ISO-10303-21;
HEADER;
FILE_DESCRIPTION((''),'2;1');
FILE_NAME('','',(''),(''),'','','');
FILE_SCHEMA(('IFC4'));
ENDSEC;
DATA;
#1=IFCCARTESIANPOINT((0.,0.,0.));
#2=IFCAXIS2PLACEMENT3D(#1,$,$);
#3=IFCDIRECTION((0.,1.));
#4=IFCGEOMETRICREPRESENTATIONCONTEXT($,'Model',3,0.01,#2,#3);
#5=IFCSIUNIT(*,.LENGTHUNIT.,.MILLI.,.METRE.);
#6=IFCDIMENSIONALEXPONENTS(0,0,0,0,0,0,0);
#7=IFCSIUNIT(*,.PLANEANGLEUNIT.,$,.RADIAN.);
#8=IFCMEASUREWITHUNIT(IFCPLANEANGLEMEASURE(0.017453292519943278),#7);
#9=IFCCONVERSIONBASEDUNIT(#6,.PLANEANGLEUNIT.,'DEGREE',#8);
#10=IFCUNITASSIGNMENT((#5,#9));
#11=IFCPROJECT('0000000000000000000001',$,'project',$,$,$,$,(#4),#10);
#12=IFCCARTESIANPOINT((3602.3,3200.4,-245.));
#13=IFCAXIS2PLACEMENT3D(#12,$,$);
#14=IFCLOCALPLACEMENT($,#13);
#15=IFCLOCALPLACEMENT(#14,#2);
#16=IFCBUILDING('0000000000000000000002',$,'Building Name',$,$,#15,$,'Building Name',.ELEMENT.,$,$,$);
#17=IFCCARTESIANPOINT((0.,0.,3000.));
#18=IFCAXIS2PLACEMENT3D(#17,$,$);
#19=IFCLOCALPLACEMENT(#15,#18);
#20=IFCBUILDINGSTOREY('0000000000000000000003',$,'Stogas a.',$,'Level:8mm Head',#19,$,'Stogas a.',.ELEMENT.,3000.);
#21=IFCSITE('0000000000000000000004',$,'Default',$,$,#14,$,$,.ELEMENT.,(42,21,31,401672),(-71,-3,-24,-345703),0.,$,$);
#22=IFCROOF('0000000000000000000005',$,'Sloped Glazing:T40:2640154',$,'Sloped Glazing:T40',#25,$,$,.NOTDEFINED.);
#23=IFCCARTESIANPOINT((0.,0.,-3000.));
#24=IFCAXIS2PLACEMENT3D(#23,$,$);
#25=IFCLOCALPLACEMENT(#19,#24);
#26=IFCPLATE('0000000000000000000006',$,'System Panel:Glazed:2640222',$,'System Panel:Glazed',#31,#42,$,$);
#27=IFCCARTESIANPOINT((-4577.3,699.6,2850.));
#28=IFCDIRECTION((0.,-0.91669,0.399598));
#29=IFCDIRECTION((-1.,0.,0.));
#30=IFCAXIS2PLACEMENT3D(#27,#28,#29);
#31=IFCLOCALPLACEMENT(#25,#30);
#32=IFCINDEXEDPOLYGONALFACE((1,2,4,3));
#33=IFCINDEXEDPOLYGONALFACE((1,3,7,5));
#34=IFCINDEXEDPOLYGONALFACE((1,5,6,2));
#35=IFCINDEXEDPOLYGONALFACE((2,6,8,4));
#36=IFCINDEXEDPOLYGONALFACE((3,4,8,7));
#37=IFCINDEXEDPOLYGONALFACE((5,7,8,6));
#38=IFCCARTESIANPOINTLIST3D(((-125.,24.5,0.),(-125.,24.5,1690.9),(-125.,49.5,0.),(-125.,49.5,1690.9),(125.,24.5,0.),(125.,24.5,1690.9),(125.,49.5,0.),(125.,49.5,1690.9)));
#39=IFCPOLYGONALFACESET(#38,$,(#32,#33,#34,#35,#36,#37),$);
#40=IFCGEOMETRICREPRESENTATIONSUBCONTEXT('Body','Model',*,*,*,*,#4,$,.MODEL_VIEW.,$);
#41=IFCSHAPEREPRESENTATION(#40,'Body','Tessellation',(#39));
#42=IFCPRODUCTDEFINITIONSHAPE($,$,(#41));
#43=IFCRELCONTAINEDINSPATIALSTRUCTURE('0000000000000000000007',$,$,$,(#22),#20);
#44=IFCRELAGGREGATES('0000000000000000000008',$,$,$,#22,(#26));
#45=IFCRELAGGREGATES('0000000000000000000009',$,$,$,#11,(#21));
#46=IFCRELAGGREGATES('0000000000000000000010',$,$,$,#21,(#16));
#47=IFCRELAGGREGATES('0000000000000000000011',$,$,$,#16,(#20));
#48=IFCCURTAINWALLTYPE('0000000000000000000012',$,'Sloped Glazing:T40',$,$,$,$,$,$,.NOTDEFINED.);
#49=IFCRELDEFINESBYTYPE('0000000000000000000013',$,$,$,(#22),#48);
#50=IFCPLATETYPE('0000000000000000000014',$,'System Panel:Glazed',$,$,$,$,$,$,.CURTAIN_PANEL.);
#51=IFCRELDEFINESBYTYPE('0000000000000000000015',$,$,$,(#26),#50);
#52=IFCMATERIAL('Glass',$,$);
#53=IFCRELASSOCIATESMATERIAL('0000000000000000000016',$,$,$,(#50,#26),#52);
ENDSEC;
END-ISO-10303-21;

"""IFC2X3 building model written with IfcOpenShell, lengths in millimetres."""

from ifc_helpers import new_model, entity, si_unit, converted_unit, direction, frame, origin, origin_2d_with_axis, place, context, subcontext, project, spatial, rectangle, extrude, source, transform, mapped, material, type_object, type_shapes, element, aggregate, save


model = new_model("IFC2X3")

# Units and contexts
model_context = context("Model", 3, precision=0.01, world=origin(), true_north=direction((0.0, 1.0)))
body_context = subcontext(model_context, "Body", "Model", "MODEL_VIEW")
ifc_project = project(units=[si_unit("LENGTHUNIT", "METRE", prefix="MILLI"), converted_unit("PLANEANGLEUNIT", "DEGREE", entity("IfcPlaneAngleMeasure", 0.017453292519943278), si_unit("PLANEANGLEUNIT", "RADIAN"), dimensions=[0, 0, 0, 0, 0, 0, 0])], contexts=[model_context])

# Site, building, storey
site_placement = place(None, frame((3602.3, 3200.4, -245.0)))
site = spatial("IfcSite", under=ifc_project, at=site_placement, Name="Default", CompositionType="ELEMENT", RefLatitude=(42, 21, 31, 401672), RefLongitude=(-71, -3, -24, -345703), RefElevation=0.0)
building_placement = place(site_placement, origin())
building = spatial("IfcBuilding", under=site, at=building_placement, Name="Building Name", LongName="Building Name", CompositionType="ELEMENT")
storey_placement = place(building_placement, frame((0.0, 0.0, 3000.0)))
storey = spatial("IfcBuildingStorey", under=building, at=storey_placement, Name="Stogas a.", ObjectType="Level:8mm Head", LongName="Stogas a.", CompositionType="ELEMENT", Elevation=3000.0)

# Roof
curtain_wall_type = type_object("IfcCurtainWallType", Name="Sloped Glazing:T40", PredefinedType="NOTDEFINED")
roof_1_placement = place(storey_placement, frame((0.0, 0.0, -3000.0)))
roof_1 = element("IfcRoof", 1, at=roof_1_placement, inside=storey, type_object=curtain_wall_type, Name="Sloped Glazing:T40:2640154", ObjectType="Sloped Glazing:T40", ShapeType="NOTDEFINED")

# Plate
ifc_material_1 = material(Name="Glass")
plate_type = type_object("IfcPlateType", Name="System Panel:Glazed", PredefinedType="CURTAIN_PANEL", material=ifc_material_1)
shared_shape_1 = source(origin(), body_context, "Body", "SweptSolid", [
    extrude(rectangle(XDim=25.0, YDim=250.0, at=origin_2d_with_axis()), frame((0.0, 37.0, 0.0), z_axis=(0.0, 0.0, 1.0), x_axis=(0.0, 1.0, 0.0)), (0.0, 0.0, 1.0), 1690.9),
])
type_shapes(plate_type, [shared_shape_1])
plate_placement = place(roof_1_placement, frame((-4577.3, 699.6, 2850.0), z_axis=(0.0, -0.91669, 0.399598), x_axis=(-1.0, 0.0, 0.0)))
plate = element("IfcPlate", 2, at=plate_placement, type_object=plate_type, material=ifc_material_1, Name="System Panel:Glazed:2640222", ObjectType="System Panel:Glazed", context=body_context, shape_type="MappedRepresentation", body=[
    mapped(shared_shape_1, transform((0.0, 0.0, 0.0), scale=1.0)),
])
aggregate(roof_1, [plate])

save(model, "model.ifc")
